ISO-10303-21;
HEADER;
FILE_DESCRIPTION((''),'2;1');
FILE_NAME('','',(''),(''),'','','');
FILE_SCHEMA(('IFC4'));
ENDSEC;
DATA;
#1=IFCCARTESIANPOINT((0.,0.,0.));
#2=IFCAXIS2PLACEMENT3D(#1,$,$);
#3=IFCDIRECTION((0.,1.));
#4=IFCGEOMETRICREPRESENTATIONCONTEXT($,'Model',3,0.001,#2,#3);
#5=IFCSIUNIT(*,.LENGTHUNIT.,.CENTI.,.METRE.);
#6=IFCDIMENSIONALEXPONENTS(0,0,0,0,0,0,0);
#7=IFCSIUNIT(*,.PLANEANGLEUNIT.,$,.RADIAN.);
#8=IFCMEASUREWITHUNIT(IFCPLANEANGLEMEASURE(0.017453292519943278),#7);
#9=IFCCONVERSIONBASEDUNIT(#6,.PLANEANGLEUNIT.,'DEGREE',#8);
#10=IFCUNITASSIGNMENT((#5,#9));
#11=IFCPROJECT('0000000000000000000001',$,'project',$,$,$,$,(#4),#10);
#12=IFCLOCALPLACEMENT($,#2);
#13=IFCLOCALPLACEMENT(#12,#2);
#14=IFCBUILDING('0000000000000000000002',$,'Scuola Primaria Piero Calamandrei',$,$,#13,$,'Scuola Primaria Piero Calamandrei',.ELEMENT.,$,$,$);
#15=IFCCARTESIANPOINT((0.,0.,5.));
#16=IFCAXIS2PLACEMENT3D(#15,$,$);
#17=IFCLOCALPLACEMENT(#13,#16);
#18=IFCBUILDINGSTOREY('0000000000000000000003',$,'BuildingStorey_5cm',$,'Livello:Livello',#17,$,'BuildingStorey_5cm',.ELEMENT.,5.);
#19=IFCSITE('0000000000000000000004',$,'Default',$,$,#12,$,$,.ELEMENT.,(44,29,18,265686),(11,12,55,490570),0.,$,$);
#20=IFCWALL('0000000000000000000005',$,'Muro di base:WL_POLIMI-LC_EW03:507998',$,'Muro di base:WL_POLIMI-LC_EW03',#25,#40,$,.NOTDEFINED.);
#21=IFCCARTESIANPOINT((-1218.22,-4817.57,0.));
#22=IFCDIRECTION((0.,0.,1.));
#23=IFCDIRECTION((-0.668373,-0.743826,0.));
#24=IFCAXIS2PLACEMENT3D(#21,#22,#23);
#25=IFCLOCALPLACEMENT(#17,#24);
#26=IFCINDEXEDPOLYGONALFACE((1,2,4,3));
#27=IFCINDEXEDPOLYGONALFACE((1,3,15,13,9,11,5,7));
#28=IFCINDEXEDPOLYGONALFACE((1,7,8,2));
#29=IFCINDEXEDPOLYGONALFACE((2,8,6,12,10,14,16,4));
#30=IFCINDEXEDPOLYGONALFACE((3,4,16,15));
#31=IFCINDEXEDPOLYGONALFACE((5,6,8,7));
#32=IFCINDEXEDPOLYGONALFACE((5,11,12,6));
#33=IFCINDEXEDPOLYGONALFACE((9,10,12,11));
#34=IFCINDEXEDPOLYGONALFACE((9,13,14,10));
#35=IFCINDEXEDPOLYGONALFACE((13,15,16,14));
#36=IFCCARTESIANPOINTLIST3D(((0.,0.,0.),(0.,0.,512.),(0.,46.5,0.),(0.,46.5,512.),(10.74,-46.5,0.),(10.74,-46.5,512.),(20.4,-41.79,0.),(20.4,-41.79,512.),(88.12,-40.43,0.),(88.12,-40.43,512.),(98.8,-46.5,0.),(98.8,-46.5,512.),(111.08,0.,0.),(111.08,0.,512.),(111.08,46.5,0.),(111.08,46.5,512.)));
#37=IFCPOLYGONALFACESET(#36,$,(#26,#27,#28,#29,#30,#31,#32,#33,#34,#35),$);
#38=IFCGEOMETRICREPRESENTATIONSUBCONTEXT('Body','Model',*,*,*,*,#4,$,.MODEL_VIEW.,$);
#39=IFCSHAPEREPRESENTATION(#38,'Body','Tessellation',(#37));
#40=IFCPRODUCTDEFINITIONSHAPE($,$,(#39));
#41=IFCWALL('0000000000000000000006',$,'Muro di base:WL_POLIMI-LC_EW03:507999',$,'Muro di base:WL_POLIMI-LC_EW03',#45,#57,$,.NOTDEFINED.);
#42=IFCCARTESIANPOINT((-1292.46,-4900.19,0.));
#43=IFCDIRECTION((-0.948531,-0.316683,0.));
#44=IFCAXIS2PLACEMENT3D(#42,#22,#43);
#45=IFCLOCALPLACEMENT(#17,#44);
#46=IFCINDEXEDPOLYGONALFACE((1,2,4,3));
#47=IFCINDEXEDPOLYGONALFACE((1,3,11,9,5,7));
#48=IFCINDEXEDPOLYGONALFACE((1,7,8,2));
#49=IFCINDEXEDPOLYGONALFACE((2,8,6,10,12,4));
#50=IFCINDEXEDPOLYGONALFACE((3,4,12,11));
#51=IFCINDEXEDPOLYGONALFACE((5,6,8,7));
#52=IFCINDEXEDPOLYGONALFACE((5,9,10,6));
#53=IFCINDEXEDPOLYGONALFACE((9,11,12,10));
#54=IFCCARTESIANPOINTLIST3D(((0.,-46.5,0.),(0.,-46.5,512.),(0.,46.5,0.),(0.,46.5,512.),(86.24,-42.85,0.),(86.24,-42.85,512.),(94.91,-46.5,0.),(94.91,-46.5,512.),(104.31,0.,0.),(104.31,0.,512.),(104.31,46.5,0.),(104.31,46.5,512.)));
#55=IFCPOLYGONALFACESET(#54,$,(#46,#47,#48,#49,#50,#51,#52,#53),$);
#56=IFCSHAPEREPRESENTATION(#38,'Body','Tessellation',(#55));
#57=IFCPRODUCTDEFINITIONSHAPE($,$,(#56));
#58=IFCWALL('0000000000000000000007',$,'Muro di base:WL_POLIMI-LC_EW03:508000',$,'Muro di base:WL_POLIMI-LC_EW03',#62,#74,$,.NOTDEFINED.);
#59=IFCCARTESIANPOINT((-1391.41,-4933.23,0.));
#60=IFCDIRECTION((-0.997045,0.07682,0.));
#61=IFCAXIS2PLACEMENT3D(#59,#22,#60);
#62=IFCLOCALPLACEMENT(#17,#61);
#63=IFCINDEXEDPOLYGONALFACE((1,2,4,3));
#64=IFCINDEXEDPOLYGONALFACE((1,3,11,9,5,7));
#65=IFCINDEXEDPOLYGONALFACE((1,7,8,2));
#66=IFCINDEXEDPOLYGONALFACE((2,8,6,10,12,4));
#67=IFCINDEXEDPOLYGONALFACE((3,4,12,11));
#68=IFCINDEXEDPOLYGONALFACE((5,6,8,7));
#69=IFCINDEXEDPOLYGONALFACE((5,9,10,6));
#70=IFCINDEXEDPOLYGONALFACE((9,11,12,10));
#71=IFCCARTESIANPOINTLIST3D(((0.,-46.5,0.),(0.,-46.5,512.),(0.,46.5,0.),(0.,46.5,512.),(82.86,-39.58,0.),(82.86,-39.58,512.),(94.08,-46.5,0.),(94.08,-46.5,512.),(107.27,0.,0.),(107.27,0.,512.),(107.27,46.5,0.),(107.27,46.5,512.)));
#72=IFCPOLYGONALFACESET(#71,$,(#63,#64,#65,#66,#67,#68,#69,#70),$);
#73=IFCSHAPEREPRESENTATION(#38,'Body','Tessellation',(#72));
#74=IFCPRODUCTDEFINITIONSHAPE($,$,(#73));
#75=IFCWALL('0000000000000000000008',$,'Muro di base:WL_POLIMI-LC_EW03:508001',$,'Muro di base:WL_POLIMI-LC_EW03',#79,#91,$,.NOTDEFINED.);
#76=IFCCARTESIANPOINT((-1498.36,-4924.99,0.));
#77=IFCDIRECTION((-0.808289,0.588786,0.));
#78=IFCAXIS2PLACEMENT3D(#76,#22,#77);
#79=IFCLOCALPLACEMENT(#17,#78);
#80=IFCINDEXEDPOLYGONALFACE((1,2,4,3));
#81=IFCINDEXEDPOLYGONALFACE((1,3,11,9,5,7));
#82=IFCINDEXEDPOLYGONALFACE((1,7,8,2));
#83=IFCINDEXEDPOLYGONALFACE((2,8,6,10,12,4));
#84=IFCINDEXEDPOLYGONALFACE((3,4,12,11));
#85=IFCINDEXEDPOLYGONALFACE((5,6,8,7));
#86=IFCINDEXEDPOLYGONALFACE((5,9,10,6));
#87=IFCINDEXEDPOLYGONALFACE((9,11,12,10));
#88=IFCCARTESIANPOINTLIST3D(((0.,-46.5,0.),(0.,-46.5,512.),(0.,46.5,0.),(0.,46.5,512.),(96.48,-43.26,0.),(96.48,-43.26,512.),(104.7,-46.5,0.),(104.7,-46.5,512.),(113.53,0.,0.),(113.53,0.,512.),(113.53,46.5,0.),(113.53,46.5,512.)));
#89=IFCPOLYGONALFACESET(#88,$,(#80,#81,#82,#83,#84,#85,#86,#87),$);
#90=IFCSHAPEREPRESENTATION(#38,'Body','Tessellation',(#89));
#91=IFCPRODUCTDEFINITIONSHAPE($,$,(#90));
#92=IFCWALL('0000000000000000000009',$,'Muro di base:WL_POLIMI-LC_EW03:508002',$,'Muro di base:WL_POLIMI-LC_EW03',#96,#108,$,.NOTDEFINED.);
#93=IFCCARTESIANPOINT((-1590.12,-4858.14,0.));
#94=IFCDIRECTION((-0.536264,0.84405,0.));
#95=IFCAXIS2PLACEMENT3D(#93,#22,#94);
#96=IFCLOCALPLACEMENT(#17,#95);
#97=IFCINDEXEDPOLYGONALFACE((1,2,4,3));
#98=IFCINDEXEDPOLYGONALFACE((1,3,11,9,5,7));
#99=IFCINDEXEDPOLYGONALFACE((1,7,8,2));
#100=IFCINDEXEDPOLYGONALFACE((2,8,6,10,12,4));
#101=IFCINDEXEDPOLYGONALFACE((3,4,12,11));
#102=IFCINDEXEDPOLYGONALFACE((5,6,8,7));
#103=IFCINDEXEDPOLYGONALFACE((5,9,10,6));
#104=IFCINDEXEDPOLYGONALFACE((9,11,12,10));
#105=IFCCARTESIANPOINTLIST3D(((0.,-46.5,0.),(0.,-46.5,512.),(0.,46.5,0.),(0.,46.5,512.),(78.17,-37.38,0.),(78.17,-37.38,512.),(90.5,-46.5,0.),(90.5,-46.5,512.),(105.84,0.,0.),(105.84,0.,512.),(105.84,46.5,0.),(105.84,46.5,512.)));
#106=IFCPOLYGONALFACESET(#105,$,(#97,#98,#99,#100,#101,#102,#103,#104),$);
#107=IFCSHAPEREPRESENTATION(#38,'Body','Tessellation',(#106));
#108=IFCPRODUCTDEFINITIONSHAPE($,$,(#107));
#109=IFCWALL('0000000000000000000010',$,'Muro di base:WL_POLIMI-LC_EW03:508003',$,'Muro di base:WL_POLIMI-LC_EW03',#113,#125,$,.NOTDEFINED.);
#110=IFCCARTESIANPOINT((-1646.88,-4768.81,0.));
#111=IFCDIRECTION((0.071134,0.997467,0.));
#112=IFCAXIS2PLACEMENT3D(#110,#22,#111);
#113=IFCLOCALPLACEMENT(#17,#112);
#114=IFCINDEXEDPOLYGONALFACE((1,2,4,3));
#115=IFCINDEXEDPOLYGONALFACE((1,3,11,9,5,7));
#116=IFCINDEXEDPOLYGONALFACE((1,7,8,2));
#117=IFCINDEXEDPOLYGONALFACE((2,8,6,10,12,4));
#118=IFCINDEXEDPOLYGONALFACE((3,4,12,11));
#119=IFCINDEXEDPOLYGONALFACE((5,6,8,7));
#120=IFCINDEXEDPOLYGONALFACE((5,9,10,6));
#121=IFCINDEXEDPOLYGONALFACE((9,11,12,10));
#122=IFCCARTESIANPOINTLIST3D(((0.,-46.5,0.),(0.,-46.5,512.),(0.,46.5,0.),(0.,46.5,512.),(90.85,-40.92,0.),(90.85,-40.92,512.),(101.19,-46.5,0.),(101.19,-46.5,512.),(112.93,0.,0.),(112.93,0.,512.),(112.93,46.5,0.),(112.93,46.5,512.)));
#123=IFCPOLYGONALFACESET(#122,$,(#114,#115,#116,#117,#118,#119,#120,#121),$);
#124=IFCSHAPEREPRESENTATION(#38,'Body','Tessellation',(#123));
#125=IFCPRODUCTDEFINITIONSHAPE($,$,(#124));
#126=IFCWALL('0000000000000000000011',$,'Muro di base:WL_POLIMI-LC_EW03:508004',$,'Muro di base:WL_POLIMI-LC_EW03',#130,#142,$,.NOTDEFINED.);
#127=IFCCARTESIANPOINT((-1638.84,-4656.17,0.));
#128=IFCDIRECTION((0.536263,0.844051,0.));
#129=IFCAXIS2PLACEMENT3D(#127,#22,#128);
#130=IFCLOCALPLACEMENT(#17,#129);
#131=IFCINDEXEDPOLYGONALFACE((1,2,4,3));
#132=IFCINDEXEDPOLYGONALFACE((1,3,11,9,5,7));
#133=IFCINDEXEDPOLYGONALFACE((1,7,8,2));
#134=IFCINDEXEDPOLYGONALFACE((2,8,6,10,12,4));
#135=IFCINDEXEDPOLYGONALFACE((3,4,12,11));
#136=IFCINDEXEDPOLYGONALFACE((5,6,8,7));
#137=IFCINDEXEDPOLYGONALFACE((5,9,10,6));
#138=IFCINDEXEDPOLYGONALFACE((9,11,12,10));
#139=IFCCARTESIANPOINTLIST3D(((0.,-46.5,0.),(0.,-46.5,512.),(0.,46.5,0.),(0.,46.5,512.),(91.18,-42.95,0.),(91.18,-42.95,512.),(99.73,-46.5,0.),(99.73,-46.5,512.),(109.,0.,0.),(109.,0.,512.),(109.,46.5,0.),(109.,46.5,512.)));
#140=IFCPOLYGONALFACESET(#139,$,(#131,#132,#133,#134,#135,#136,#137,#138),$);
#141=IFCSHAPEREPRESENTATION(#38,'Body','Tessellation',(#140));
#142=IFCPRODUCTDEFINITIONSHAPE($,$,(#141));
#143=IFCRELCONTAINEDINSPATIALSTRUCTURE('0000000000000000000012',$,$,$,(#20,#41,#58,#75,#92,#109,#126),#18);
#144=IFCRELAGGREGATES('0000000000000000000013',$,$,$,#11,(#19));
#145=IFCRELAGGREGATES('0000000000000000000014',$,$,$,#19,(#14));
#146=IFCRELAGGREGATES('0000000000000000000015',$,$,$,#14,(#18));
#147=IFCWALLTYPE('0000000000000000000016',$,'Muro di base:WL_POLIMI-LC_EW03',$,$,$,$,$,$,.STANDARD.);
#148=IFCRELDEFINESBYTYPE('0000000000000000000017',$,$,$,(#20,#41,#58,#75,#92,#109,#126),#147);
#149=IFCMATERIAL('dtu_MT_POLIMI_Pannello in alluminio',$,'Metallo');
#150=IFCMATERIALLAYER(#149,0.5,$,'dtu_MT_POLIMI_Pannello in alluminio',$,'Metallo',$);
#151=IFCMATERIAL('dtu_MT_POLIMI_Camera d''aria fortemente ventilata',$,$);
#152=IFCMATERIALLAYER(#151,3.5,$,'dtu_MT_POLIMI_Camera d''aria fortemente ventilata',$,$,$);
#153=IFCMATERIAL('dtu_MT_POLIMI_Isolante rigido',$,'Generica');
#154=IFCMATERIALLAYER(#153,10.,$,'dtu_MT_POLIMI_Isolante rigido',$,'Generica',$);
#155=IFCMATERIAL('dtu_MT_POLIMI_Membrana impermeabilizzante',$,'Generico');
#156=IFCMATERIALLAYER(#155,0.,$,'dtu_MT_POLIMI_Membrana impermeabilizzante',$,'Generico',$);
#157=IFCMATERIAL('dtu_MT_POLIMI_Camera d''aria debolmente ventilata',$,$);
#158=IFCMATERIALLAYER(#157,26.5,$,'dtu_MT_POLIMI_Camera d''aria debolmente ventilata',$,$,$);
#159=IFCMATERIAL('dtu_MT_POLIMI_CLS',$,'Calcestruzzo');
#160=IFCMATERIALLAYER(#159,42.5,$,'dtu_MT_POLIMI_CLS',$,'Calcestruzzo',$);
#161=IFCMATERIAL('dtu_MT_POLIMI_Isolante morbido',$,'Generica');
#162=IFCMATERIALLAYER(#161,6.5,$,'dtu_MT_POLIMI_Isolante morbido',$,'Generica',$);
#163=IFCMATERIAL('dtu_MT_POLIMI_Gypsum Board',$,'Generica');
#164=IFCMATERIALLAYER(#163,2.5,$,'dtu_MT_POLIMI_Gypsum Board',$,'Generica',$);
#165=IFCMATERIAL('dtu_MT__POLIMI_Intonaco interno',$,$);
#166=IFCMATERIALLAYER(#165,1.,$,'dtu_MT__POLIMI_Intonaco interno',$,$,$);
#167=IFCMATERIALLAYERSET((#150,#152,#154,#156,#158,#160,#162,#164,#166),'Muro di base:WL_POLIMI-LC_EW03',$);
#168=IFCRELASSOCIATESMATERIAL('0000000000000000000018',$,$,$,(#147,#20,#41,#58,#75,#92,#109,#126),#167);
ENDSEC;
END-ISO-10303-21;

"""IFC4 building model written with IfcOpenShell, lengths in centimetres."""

from ifc_helpers import new_model, entity, si_unit, converted_unit, direction, frame, frame_2d, origin, place, context, subcontext, project, spatial, polyline, rectangle, extrude, clip, bounded_halfspace, material, layer, layer_set, layer_usage, type_object, element, save


model = new_model("IFC4")

# Units and contexts
model_context = context("Model", 3, precision=0.001, world=origin(), true_north=direction((0.0, 1.0)))
body_context = subcontext(model_context, "Body", "Model", "MODEL_VIEW")
ifc_project = project(units=[si_unit("LENGTHUNIT", "METRE", prefix="CENTI"), converted_unit("PLANEANGLEUNIT", "DEGREE", entity("IfcPlaneAngleMeasure", 0.017453292519943278), si_unit("PLANEANGLEUNIT", "RADIAN"), dimensions=[0, 0, 0, 0, 0, 0, 0])], contexts=[model_context])

# Site, building, storey
site_placement = place(None, origin())
site = spatial("IfcSite", under=ifc_project, at=site_placement, Name="Default", CompositionType="ELEMENT", RefLatitude=(44, 29, 18, 265686), RefLongitude=(11, 12, 55, 490570), RefElevation=0.0)
building_placement = place(site_placement, origin())
building = spatial("IfcBuilding", under=site, at=building_placement, Name="Scuola Primaria Piero Calamandrei", LongName="Scuola Primaria Piero Calamandrei", CompositionType="ELEMENT")
storey_placement = place(building_placement, frame((0.0, 0.0, 5.0)))
storey = spatial("IfcBuildingStorey", under=building, at=storey_placement, Name="BuildingStorey_5cm", ObjectType="Livello:Livello", LongName="BuildingStorey_5cm", CompositionType="ELEMENT", Elevation=5.0)

# Shared definitions
ifc_material_1 = material(Name="dtu_MT_POLIMI_Isolante rigido", Category="Generica")
ifc_material_2 = material(Name="dtu_MT_POLIMI_CLS", Category="Calcestruzzo")

# Walls
ifc_material_3 = material(Name="dtu_MT_POLIMI_Pannello in alluminio", Category="Metallo")
ifc_material_4 = material(Name="dtu_MT_POLIMI_Camera d'aria fortemente ventilata")
ifc_material_5 = material(Name="dtu_MT_POLIMI_Membrana impermeabilizzante", Category="Generico")
ifc_material_6 = material(Name="dtu_MT_POLIMI_Camera d'aria debolmente ventilata")
ifc_material_7 = material(Name="dtu_MT__POLIMI_Intonaco interno")
ifc_layer_1 = layer(ifc_material_3, 0.5, Name="dtu_MT_POLIMI_Pannello in alluminio", Category="Metallo")
ifc_layer_2 = layer(ifc_material_4, 3.5, Name="dtu_MT_POLIMI_Camera d'aria fortemente ventilata")
ifc_layer_3 = layer(ifc_material_1, 10.0, Name="dtu_MT_POLIMI_Isolante rigido", Category="Generica")
ifc_layer_4 = layer(ifc_material_5, 0.0, Name="dtu_MT_POLIMI_Membrana impermeabilizzante", Category="Generico")
ifc_layer_5 = layer(ifc_material_6, 26.5, Name="dtu_MT_POLIMI_Camera d'aria debolmente ventilata")
ifc_layer_6 = layer(ifc_material_2, 42.5, Name="dtu_MT_POLIMI_CLS", Category="Calcestruzzo")
ifc_material_8 = material(Name="dtu_MT_POLIMI_Isolante morbido", Category="Generica")
ifc_layer_7 = layer(ifc_material_8, 6.5, Name="dtu_MT_POLIMI_Isolante morbido", Category="Generica")
ifc_material_9 = material(Name="dtu_MT_POLIMI_Gypsum Board", Category="Generica")
ifc_layer_8 = layer(ifc_material_9, 2.5, Name="dtu_MT_POLIMI_Gypsum Board", Category="Generica")
ifc_layer_9 = layer(ifc_material_7, 1.0, Name="dtu_MT__POLIMI_Intonaco interno")
ifc_layer_set_1 = layer_set([ifc_layer_1, ifc_layer_2, ifc_layer_3, ifc_layer_4, ifc_layer_5, ifc_layer_6, ifc_layer_7, ifc_layer_8, ifc_layer_9], Name="Muro di base:WL_POLIMI-LC_EW03")
wall_type_1 = type_object("IfcWallType", Name="Muro di base:WL_POLIMI-LC_EW03", PredefinedType="STANDARD", material=ifc_layer_set_1)
ifc_layer_usage_1 = layer_usage(ifc_layer_set_1, "AXIS2", "NEGATIVE", 46.5)
wall_1_placement = place(storey_placement, frame((-1218.22, -4817.57, 0.0), z_axis=(0.0, 0.0, 1.0), x_axis=(-0.668373, -0.743826, 0.0)))
element("IfcWall", 1, at=wall_1_placement, inside=storey, type_object=wall_type_1, material=ifc_layer_usage_1, Name="Muro di base:WL_POLIMI-LC_EW03:507998", ObjectType="Muro di base:WL_POLIMI-LC_EW03", PredefinedType="NOTDEFINED", context=body_context, shape_type="Clipping", body=[
    clip(clip(clip(clip(extrude(rectangle(XDim=111.08, YDim=93.0, at=frame_2d((55.54, 0.0), x_axis=(-1.0, 0.0))), origin(), (0.0, 0.0, 1.0), 512.0), bounded_halfspace(frame((88.12, -40.43, 0.0), z_axis=(-0.493879, -0.86953, 0.0), x_axis=(0.86953, -0.493879, 0.0)), True, frame((88.12, -40.43, 0.0), z_axis=(-0.493879, -0.86953, 0.0), x_axis=(0.86953, -0.493879, 0.0)), polyline([(0.0, 0.0), (374.42, 0.0), (374.42, 15605.76), (0.0, 15605.76), (0.0, 0.0)]))), bounded_halfspace(frame((88.12, -40.43, 512.0), z_axis=(-0.86953, 0.493879, 0.0), x_axis=(0.493879, 0.86953, 0.0)), True, frame((88.12, -40.43, 512.0), z_axis=(-0.86953, 0.493879, 0.0), x_axis=(0.493879, 0.86953, 0.0)), polyline([(0.0, 0.0), (1417.32, 0.0), (1417.32, 15605.76), (0.0, 15605.76), (0.0, 0.0)]))), bounded_halfspace(frame((20.4, -41.79, 512.0), z_axis=(0.438691, -0.898638, 0.0), x_axis=(0.898638, 0.438691, 0.0)), True, frame((20.4, -41.79, 512.0), z_axis=(0.438691, -0.898638, 0.0), x_axis=(0.898638, 0.438691, 0.0)), polyline([(0.0, 0.0), (-327.48, 0.0), (-327.48, -15605.76), (0.0, -15605.76), (0.0, 0.0)]))), bounded_halfspace(frame((20.4, -41.79, 0.0), z_axis=(0.898638, 0.438691, 0.0), x_axis=(-0.438691, 0.898638, 0.0)), True, frame((20.4, -41.79, 0.0), z_axis=(0.898638, 0.438691, 0.0), x_axis=(-0.438691, 0.898638, 0.0)), polyline([(0.0, 0.0), (1417.32, 0.0), (1417.32, 15605.76), (0.0, 15605.76), (0.0, 0.0)]))),
])
ifc_layer_usage_2 = layer_usage(ifc_layer_set_1, "AXIS2", "NEGATIVE", 46.5)
wall_2_placement = place(storey_placement, frame((-1292.46, -4900.19, 0.0), z_axis=(0.0, 0.0, 1.0), x_axis=(-0.948531, -0.316683, 0.0)))
element("IfcWall", 2, at=wall_2_placement, inside=storey, type_object=wall_type_1, material=ifc_layer_usage_2, Name="Muro di base:WL_POLIMI-LC_EW03:507999", ObjectType="Muro di base:WL_POLIMI-LC_EW03", PredefinedType="NOTDEFINED", context=body_context, shape_type="Clipping", body=[
    clip(clip(extrude(rectangle(XDim=104.31, YDim=93.0, at=frame_2d((52.16, 0.0), x_axis=(-1.0, 0.0))), origin(), (0.0, 0.0, 1.0), 512.0), bounded_halfspace(frame((86.24, -42.85, 0.0), z_axis=(-0.388614, -0.921401, 0.0), x_axis=(0.921401, -0.388614, 0.0)), True, frame((86.24, -42.85, 0.0), z_axis=(-0.388614, -0.921401, 0.0), x_axis=(0.921401, -0.388614, 0.0)), polyline([(0.0, 0.0), (286.66, 0.0), (286.66, 15605.76), (0.0, 15605.76), (0.0, 0.0)]))), bounded_halfspace(frame((86.24, -42.85, 512.0), z_axis=(-0.921401, 0.388614, 0.0), x_axis=(0.388614, 0.921401, 0.0)), True, frame((86.24, -42.85, 512.0), z_axis=(-0.921401, 0.388614, 0.0), x_axis=(0.388614, 0.921401, 0.0)), polyline([(0.0, 0.0), (1417.32, 0.0), (1417.32, 15605.76), (0.0, 15605.76), (0.0, 0.0)]))),
])
ifc_layer_usage_3 = layer_usage(ifc_layer_set_1, "AXIS2", "NEGATIVE", 46.5)
wall_3_placement = place(storey_placement, frame((-1391.41, -4933.23, 0.0), z_axis=(0.0, 0.0, 1.0), x_axis=(-0.997045, 0.07682, 0.0)))
element("IfcWall", 3, at=wall_3_placement, inside=storey, type_object=wall_type_1, material=ifc_layer_usage_3, Name="Muro di base:WL_POLIMI-LC_EW03:508000", ObjectType="Muro di base:WL_POLIMI-LC_EW03", PredefinedType="NOTDEFINED", context=body_context, shape_type="Clipping", body=[
    clip(clip(extrude(rectangle(XDim=107.27, YDim=93.0, at=frame_2d((53.63, 0.0), x_axis=(-1.0, 0.0))), origin(), (0.0, 0.0, 1.0), 512.0), bounded_halfspace(frame((82.86, -39.58, 0.0), z_axis=(-0.524953, -0.851131, 0.0), x_axis=(0.851131, -0.524953, 0.0)), True, frame((82.86, -39.58, 0.0), z_axis=(-0.524953, -0.851131, 0.0), x_axis=(0.851131, -0.524953, 0.0)), polyline([(0.0, 0.0), (401.93, 0.0), (401.93, 15605.76), (0.0, 15605.76), (0.0, 0.0)]))), bounded_halfspace(frame((82.86, -39.58, 512.0), z_axis=(-0.851131, 0.524953, 0.0), x_axis=(0.524953, 0.851131, 0.0)), True, frame((82.86, -39.58, 512.0), z_axis=(-0.851131, 0.524953, 0.0), x_axis=(0.524953, 0.851131, 0.0)), polyline([(0.0, 0.0), (1417.32, 0.0), (1417.32, 15605.76), (0.0, 15605.76), (0.0, 0.0)]))),
])
ifc_layer_usage_4 = layer_usage(ifc_layer_set_1, "AXIS2", "NEGATIVE", 46.5)
wall_4_placement = place(storey_placement, frame((-1498.36, -4924.99, 0.0), z_axis=(0.0, 0.0, 1.0), x_axis=(-0.808289, 0.588786, 0.0)))
element("IfcWall", 4, at=wall_4_placement, inside=storey, type_object=wall_type_1, material=ifc_layer_usage_4, Name="Muro di base:WL_POLIMI-LC_EW03:508001", ObjectType="Muro di base:WL_POLIMI-LC_EW03", PredefinedType="NOTDEFINED", context=body_context, shape_type="Clipping", body=[
    clip(clip(extrude(rectangle(XDim=113.53, YDim=93.0, at=frame_2d((56.76, 0.0), x_axis=(-1.0, 0.0))), origin(), (0.0, 0.0, 1.0), 512.0), bounded_halfspace(frame((96.48, -43.26, 0.0), z_axis=(-0.366492, -0.930421, 0.0), x_axis=(0.930421, -0.366492, 0.0)), True, frame((96.48, -43.26, 0.0), z_axis=(-0.366492, -0.930421, 0.0), x_axis=(0.930421, -0.366492, 0.0)), polyline([(0.0, 0.0), (269.08, 0.0), (269.08, 15605.76), (0.0, 15605.76), (0.0, 0.0)]))), bounded_halfspace(frame((96.48, -43.26, 512.0), z_axis=(-0.930421, 0.366492, 0.0), x_axis=(0.366492, 0.930421, 0.0)), True, frame((96.48, -43.26, 512.0), z_axis=(-0.930421, 0.366492, 0.0), x_axis=(0.366492, 0.930421, 0.0)), polyline([(0.0, 0.0), (1417.32, 0.0), (1417.32, 15605.76), (0.0, 15605.76), (0.0, 0.0)]))),
])
ifc_layer_usage_5 = layer_usage(ifc_layer_set_1, "AXIS2", "NEGATIVE", 46.5)
wall_5_placement = place(storey_placement, frame((-1590.12, -4858.14, 0.0), z_axis=(0.0, 0.0, 1.0), x_axis=(-0.536264, 0.84405, 0.0)))
element("IfcWall", 5, at=wall_5_placement, inside=storey, type_object=wall_type_1, material=ifc_layer_usage_5, Name="Muro di base:WL_POLIMI-LC_EW03:508002", ObjectType="Muro di base:WL_POLIMI-LC_EW03", PredefinedType="NOTDEFINED", context=body_context, shape_type="Clipping", body=[
    clip(clip(extrude(rectangle(XDim=105.84, YDim=93.0, at=frame_2d((52.92, 0.0), x_axis=(-1.0, 0.0))), origin(), (0.0, 0.0, 1.0), 512.0), bounded_halfspace(frame((78.17, -37.38, 0.0), z_axis=(-0.594946, -0.803765, 0.0), x_axis=(0.803765, -0.594946, 0.0)), True, frame((78.17, -37.38, 0.0), z_axis=(-0.594946, -0.803765, 0.0), x_axis=(0.803765, -0.594946, 0.0)), polyline([(0.0, 0.0), (467.48, 0.0), (467.48, 15605.76), (0.0, 15605.76), (0.0, 0.0)]))), bounded_halfspace(frame((78.17, -37.38, 512.0), z_axis=(-0.803765, 0.594946, 0.0), x_axis=(0.594946, 0.803765, 0.0)), True, frame((78.17, -37.38, 512.0), z_axis=(-0.803765, 0.594946, 0.0), x_axis=(0.594946, 0.803765, 0.0)), polyline([(0.0, 0.0), (1417.32, 0.0), (1417.32, 15605.76), (0.0, 15605.76), (0.0, 0.0)]))),
])
ifc_layer_usage_6 = layer_usage(ifc_layer_set_1, "AXIS2", "NEGATIVE", 46.5)
wall_6_placement = place(storey_placement, frame((-1646.88, -4768.81, 0.0), z_axis=(0.0, 0.0, 1.0), x_axis=(0.071134, 0.997467, 0.0)))
element("IfcWall", 6, at=wall_6_placement, inside=storey, type_object=wall_type_1, material=ifc_layer_usage_6, Name="Muro di base:WL_POLIMI-LC_EW03:508003", ObjectType="Muro di base:WL_POLIMI-LC_EW03", PredefinedType="NOTDEFINED", context=body_context, shape_type="Clipping", body=[
    clip(clip(extrude(rectangle(XDim=112.93, YDim=93.0, at=frame_2d((56.47, 0.0), x_axis=(-1.0, 0.0))), origin(), (0.0, 0.0, 1.0), 512.0), bounded_halfspace(frame((90.85, -40.92, 0.0), z_axis=(-0.474864, -0.880059, 0.0), x_axis=(0.880059, -0.474864, 0.0)), True, frame((90.85, -40.92, 0.0), z_axis=(-0.474864, -0.880059, 0.0), x_axis=(0.880059, -0.474864, 0.0)), polyline([(0.0, 0.0), (357.99, 0.0), (357.99, 15605.76), (0.0, 15605.76), (0.0, 0.0)]))), bounded_halfspace(frame((90.85, -40.92, 512.0), z_axis=(-0.880059, 0.474864, 0.0), x_axis=(0.474864, 0.880059, 0.0)), True, frame((90.85, -40.92, 512.0), z_axis=(-0.880059, 0.474864, 0.0), x_axis=(0.474864, 0.880059, 0.0)), polyline([(0.0, 0.0), (1417.32, 0.0), (1417.32, 15605.76), (0.0, 15605.76), (0.0, 0.0)]))),
])
ifc_layer_usage_7 = layer_usage(ifc_layer_set_1, "AXIS2", "NEGATIVE", 46.5)
wall_7_placement = place(storey_placement, frame((-1638.84, -4656.17, 0.0), z_axis=(0.0, 0.0, 1.0), x_axis=(0.536263, 0.844051, 0.0)))
element("IfcWall", 7, at=wall_7_placement, inside=storey, type_object=wall_type_1, material=ifc_layer_usage_7, Name="Muro di base:WL_POLIMI-LC_EW03:508004", ObjectType="Muro di base:WL_POLIMI-LC_EW03", PredefinedType="NOTDEFINED", context=body_context, shape_type="Clipping", body=[
    clip(clip(extrude(rectangle(XDim=109.0, YDim=93.0, at=frame_2d((54.5, 0.0), x_axis=(-1.0, 0.0))), origin(), (0.0, 0.0, 1.0), 512.0), bounded_halfspace(frame((91.18, -42.95, 0.0), z_axis=(-0.383253, -0.923643, 0.0), x_axis=(0.923643, -0.383253, 0.0)), True, frame((91.18, -42.95, 0.0), z_axis=(-0.383253, -0.923643, 0.0), x_axis=(0.923643, -0.383253, 0.0)), polyline([(0.0, 0.0), (282.38, 0.0), (282.38, 15605.76), (0.0, 15605.76), (0.0, 0.0)]))), bounded_halfspace(frame((91.18, -42.95, 512.0), z_axis=(-0.923643, 0.383253, 0.0), x_axis=(0.383253, 0.923643, 0.0)), True, frame((91.18, -42.95, 512.0), z_axis=(-0.923643, 0.383253, 0.0), x_axis=(0.383253, 0.923643, 0.0)), polyline([(0.0, 0.0), (1417.32, 0.0), (1417.32, 15605.76), (0.0, 15605.76), (0.0, 0.0)]))),
])

save(model, "model.ifc")
